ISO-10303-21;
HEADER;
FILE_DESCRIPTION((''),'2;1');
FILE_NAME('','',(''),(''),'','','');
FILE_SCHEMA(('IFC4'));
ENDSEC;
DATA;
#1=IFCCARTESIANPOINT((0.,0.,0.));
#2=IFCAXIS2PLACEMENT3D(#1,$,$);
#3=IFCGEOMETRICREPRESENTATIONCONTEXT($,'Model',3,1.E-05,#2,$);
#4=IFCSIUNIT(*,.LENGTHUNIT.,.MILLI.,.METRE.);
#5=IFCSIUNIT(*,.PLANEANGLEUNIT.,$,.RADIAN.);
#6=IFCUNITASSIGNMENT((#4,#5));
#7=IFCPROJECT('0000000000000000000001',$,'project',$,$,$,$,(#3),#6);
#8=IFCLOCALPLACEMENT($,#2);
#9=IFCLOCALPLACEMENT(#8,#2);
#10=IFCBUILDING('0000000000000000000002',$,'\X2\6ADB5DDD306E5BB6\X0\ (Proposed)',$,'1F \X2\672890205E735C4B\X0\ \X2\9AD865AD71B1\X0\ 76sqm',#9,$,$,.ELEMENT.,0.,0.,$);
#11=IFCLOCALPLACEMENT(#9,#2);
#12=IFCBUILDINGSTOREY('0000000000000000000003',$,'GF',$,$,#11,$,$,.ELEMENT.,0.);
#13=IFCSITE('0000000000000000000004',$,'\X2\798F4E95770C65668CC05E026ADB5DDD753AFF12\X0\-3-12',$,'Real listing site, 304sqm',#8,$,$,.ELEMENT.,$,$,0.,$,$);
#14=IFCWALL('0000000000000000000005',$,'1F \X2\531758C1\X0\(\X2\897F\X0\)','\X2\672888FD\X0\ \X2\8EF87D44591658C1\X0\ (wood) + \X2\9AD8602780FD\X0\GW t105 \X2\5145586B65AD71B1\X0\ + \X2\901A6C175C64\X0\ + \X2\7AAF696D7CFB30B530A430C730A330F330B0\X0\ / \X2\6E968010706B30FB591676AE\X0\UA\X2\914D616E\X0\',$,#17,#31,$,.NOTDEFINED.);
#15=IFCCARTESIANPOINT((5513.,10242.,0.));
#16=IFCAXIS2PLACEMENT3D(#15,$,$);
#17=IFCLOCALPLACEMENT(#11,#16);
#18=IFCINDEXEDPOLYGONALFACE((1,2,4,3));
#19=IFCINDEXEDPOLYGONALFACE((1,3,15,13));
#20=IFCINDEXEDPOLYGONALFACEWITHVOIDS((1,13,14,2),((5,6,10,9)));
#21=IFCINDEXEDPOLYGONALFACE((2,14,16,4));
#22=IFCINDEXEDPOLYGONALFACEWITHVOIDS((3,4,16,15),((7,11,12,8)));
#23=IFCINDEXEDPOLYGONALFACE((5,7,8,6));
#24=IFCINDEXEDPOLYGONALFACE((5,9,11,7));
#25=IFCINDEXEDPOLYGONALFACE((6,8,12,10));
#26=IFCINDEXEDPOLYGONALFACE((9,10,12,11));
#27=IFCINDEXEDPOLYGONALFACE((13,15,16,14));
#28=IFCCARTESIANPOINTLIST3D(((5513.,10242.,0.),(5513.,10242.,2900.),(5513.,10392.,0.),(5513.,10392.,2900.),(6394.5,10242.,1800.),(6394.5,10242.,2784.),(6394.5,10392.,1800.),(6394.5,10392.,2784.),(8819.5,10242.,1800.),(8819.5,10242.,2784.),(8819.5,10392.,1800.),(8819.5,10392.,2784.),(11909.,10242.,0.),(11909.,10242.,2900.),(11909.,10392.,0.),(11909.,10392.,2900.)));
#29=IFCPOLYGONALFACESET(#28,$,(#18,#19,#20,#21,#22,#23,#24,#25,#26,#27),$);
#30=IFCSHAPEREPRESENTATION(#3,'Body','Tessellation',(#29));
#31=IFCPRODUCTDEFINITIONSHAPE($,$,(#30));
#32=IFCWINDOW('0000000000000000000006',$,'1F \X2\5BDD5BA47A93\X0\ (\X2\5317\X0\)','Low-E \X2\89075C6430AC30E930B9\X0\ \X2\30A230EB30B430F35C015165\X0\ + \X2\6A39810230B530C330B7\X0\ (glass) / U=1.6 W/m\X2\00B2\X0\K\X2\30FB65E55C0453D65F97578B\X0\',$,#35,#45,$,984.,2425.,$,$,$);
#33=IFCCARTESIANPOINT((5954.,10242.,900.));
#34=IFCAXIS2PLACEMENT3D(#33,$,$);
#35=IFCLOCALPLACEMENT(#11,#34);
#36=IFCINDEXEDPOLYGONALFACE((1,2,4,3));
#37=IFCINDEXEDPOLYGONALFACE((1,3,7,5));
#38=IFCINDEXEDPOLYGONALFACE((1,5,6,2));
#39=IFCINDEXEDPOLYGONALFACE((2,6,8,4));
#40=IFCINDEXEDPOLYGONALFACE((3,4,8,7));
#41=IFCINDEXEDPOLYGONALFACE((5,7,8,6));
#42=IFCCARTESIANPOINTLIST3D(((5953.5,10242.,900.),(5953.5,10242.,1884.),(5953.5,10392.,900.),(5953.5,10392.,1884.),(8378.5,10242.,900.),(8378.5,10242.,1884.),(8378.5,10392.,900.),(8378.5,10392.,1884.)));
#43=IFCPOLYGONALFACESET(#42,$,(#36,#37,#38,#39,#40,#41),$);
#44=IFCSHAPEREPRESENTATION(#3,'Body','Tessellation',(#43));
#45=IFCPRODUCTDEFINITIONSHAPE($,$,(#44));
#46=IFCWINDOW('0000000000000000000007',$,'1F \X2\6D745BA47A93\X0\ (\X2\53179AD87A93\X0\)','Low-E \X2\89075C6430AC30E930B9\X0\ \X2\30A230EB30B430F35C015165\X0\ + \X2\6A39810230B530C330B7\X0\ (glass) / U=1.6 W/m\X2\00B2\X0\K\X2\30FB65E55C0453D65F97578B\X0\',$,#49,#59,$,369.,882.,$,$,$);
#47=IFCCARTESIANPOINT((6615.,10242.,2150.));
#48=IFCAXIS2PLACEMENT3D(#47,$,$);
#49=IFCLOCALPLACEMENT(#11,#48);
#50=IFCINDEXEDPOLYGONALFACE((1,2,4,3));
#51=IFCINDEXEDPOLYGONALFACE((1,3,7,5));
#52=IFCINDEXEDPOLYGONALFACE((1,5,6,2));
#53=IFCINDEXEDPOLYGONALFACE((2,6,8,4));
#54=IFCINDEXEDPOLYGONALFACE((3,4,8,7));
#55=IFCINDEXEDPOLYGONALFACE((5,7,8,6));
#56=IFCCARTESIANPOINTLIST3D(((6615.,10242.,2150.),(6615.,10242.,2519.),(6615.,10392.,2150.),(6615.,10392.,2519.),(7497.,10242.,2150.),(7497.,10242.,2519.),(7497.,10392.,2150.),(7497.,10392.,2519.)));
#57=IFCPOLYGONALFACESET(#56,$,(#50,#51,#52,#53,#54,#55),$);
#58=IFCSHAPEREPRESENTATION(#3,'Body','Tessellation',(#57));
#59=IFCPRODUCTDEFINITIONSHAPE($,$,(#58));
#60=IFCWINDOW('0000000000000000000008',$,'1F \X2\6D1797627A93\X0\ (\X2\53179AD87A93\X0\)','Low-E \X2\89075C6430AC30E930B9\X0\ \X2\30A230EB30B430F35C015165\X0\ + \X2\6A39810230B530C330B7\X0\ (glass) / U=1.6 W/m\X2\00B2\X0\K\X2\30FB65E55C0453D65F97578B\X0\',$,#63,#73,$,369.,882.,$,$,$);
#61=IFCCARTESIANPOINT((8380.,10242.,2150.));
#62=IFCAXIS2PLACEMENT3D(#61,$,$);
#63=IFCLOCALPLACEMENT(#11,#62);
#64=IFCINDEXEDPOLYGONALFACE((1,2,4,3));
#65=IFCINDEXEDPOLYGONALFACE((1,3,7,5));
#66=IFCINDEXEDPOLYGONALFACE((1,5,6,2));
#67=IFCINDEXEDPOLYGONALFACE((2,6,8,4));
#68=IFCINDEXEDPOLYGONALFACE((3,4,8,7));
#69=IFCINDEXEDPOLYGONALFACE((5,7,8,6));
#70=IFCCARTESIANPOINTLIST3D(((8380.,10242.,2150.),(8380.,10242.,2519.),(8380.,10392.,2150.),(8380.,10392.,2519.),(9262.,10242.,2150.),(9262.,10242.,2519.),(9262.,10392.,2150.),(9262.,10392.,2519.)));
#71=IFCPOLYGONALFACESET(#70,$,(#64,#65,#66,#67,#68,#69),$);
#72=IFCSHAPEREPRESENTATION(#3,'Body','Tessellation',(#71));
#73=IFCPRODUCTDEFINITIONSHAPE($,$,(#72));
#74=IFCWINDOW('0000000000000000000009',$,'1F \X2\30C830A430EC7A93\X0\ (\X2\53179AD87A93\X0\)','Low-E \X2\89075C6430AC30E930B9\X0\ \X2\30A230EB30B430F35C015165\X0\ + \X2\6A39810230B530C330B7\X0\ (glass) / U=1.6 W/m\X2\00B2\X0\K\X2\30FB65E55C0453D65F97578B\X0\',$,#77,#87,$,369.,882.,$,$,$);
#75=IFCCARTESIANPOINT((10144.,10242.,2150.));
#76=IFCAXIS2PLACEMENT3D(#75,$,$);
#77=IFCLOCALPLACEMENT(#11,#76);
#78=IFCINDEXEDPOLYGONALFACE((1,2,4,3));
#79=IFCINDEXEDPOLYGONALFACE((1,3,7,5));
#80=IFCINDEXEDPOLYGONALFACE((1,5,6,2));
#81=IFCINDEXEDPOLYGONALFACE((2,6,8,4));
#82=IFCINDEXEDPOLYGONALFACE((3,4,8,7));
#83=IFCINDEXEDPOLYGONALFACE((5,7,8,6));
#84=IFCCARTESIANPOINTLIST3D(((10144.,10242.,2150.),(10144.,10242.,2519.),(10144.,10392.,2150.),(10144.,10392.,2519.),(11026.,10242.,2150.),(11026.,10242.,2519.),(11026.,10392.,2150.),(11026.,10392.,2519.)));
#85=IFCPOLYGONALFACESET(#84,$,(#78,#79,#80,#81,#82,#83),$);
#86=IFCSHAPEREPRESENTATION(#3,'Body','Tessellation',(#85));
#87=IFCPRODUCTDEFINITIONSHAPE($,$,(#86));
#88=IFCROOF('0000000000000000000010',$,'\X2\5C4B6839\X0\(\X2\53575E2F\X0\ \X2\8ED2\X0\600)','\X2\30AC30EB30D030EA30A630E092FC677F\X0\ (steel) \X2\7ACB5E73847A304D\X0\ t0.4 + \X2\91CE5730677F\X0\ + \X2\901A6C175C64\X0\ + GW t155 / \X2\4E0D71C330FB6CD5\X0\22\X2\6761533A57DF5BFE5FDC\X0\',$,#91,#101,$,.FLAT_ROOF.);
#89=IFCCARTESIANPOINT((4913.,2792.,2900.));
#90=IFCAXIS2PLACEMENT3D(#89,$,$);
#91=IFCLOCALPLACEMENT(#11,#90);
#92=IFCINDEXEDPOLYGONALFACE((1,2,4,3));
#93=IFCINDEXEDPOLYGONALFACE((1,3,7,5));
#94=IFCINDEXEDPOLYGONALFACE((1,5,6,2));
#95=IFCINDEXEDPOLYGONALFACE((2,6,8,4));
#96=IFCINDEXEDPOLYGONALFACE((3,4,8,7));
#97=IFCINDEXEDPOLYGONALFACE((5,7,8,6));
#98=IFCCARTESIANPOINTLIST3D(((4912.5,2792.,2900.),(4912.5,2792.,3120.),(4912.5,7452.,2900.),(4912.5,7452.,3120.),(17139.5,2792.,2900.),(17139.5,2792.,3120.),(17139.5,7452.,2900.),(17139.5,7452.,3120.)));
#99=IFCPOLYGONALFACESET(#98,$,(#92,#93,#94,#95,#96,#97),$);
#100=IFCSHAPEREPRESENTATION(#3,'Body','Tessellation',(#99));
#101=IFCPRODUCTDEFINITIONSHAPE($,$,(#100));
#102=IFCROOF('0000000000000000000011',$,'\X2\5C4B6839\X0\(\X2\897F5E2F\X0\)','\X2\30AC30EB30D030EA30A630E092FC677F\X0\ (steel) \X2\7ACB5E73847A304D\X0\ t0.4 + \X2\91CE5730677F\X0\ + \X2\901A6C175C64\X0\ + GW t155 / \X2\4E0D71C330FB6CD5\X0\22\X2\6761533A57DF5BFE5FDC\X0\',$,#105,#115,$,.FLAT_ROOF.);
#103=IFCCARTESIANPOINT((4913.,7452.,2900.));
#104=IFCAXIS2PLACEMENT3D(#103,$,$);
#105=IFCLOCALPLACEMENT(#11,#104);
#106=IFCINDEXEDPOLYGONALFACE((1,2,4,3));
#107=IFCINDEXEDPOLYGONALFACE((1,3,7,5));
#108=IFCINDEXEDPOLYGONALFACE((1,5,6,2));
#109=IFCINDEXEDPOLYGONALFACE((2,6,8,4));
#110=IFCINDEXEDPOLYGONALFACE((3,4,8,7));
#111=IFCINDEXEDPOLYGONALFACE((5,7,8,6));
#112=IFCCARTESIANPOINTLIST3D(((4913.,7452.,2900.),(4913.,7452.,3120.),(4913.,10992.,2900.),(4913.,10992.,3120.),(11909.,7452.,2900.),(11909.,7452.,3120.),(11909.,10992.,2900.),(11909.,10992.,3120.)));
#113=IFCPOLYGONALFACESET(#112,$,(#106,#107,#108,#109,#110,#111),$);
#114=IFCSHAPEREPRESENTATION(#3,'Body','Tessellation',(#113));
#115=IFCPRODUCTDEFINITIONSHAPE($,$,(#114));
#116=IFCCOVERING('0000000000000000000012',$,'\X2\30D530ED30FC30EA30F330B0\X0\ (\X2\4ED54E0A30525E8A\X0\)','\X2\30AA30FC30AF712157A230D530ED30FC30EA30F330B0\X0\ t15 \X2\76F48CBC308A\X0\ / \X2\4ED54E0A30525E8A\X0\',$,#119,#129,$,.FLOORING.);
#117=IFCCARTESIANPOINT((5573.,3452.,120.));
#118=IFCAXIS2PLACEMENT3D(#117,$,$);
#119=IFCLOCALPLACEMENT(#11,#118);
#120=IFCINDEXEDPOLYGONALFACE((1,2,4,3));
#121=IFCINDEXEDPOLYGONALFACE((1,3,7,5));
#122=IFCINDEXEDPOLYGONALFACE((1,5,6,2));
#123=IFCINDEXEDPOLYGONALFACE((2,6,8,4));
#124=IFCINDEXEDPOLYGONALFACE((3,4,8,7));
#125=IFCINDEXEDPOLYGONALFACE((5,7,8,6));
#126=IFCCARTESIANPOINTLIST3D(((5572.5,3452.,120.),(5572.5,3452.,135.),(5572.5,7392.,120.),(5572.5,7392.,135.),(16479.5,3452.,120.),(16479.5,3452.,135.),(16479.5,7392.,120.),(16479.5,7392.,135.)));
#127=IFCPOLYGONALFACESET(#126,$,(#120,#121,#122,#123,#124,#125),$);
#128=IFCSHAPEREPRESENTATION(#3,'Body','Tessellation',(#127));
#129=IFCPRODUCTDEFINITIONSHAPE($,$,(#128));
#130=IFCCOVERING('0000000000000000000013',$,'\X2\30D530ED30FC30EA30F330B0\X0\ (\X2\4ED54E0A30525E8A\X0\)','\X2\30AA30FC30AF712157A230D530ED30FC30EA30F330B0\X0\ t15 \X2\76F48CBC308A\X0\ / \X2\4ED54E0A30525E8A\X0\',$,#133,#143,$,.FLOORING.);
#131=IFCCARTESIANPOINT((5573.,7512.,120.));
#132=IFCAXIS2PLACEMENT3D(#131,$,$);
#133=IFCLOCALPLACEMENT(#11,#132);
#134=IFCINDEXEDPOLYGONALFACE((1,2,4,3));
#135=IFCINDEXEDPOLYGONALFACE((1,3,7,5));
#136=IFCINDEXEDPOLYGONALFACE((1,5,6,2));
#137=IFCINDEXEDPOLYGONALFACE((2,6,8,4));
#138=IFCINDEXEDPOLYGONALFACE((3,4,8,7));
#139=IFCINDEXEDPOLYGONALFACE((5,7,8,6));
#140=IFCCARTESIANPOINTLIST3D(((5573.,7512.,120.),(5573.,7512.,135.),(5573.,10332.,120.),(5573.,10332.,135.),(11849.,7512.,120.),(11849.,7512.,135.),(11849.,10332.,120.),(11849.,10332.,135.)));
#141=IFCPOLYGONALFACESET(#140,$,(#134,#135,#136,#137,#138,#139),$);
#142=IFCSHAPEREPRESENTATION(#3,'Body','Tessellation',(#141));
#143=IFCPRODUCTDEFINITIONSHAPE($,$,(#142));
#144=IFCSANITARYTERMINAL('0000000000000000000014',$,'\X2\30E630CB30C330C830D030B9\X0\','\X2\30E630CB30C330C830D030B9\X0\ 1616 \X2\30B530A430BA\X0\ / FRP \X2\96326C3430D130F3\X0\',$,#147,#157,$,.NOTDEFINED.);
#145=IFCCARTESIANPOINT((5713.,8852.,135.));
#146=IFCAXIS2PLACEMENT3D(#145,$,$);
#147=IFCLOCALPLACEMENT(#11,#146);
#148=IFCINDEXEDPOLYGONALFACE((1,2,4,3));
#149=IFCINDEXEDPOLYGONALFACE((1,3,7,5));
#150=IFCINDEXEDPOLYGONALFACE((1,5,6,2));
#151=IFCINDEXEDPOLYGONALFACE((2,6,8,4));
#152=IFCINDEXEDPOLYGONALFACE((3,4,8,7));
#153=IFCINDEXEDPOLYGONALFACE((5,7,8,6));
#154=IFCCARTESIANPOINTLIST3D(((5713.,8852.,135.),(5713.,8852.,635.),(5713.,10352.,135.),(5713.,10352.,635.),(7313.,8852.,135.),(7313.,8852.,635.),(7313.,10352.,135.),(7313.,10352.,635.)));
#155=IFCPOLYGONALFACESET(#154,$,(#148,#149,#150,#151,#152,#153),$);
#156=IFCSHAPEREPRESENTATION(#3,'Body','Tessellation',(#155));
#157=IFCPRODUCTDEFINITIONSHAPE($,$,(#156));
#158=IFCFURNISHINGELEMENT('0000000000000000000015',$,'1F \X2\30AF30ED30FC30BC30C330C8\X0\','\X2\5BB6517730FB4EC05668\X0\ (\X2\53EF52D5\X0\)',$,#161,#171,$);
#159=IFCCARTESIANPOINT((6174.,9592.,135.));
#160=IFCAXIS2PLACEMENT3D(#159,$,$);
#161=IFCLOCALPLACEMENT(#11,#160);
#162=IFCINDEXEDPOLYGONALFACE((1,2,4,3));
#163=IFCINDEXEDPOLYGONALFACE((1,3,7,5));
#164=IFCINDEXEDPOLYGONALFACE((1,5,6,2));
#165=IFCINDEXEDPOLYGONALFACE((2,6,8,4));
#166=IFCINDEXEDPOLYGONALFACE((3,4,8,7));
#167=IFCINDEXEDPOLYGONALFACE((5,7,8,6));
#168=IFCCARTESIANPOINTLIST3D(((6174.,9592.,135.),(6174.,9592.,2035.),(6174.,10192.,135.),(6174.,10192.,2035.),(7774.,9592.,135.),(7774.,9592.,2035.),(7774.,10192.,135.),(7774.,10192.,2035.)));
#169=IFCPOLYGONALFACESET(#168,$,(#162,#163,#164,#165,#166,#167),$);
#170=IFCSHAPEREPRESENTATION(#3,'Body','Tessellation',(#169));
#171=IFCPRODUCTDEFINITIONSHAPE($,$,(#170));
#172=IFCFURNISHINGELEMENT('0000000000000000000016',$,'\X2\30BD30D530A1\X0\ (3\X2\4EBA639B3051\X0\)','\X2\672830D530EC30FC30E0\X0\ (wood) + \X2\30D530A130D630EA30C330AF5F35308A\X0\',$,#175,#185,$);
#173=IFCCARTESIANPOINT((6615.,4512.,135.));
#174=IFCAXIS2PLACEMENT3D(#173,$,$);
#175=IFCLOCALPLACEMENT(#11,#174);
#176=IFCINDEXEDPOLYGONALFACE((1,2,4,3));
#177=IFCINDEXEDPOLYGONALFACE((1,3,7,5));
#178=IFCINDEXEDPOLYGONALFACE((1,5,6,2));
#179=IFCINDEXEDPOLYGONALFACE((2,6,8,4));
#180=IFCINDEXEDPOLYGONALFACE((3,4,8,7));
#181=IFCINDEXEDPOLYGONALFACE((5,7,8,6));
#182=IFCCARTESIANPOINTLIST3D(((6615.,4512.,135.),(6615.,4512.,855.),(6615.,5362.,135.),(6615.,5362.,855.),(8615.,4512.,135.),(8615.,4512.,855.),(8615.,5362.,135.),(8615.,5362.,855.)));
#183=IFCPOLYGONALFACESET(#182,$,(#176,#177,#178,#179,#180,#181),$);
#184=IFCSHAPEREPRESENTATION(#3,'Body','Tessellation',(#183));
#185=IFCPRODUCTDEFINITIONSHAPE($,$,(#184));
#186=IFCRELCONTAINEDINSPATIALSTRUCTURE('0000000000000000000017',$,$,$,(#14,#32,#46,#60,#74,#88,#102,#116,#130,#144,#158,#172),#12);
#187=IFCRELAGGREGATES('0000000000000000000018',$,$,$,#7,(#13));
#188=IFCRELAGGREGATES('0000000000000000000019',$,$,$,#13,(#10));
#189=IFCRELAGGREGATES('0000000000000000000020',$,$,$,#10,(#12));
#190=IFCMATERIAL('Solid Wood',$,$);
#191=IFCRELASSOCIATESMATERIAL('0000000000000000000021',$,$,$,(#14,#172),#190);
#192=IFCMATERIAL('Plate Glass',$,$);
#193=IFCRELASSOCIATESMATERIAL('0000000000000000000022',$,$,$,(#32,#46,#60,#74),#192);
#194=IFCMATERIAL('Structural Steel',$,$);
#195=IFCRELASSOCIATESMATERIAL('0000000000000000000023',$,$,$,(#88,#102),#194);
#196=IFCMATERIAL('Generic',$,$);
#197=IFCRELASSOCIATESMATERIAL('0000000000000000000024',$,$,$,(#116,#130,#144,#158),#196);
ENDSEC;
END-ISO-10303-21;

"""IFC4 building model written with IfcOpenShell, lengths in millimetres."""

from ifc_helpers import new_model, si_unit, frame, frame_2d, origin, place, context, project, spatial, rectangle, extrude, material, element, fill, save


model = new_model("IFC4")

# Units and contexts
model_context = context("Model", 3, precision=1e-05, world=origin())
ifc_project = project(units=[si_unit("LENGTHUNIT", "METRE", prefix="MILLI"), si_unit("PLANEANGLEUNIT", "RADIAN")], contexts=[model_context])

# Site, building, storey
site_placement = place(None, origin())
site = spatial("IfcSite", under=ifc_project, at=site_placement, Name="福井県敦賀市櫛川町２-3-12", ObjectType="Real listing site, 304sqm", CompositionType="ELEMENT", RefElevation=0.0)
building_placement = place(site_placement, origin())
building = spatial("IfcBuilding", under=site, at=building_placement, Name="櫛川の家 (Proposed)", ObjectType="1F 木造平屋 高断熱 76sqm", CompositionType="ELEMENT", ElevationOfRefHeight=0.0, ElevationOfTerrain=0.0)
storey_placement = place(building_placement, origin())
storey = spatial("IfcBuildingStorey", under=building, at=storey_placement, Name="GF", CompositionType="ELEMENT", Elevation=0.0)

# Shared definitions
ifc_material_1 = material(Name="Solid Wood")

# Shared definitions
ifc_material_2 = material(Name="Plate Glass")

# Wall, openings, windows
wall_1_placement = place(storey_placement, frame((5513.0, 10242.0, 0.0)))
wall_1 = element("IfcWall", 1, at=wall_1_placement, inside=storey, material=ifc_material_1, Name="1F 北壁(西)", Description="木製 軸組外壁 (wood) + 高性能GW t105 充填断熱 + 通気層 + 窯業系サイディング / 準耐火・外皮UA配慮", PredefinedType="NOTDEFINED", context=model_context, shape_type="SweptSolid", body=[
    extrude(rectangle(XDim=6396.0, YDim=150.0, at=frame_2d((3198.0, 75.0))), frame((5513.0, 10242.0, 0.0)), (0.0, 0.0, 1.0), 2900.0),
])
opening_1_placement = place(storey_placement, frame((5954.0, 10242.0, 900.0)))
opening_1 = element("IfcOpeningElement", 2, at=opening_1_placement, cuts=wall_1, PredefinedType="NOTDEFINED", context=model_context, shape_type="SweptSolid", body=[
    extrude(rectangle(XDim=2425.0, YDim=150.0, at=frame_2d((1212.0, 75.0))), frame((5954.0, 10242.0, 900.0)), (0.0, 0.0, 1.0), 984.0),
])
opening_2_placement = place(storey_placement, frame((6615.0, 10242.0, 2150.0)))
opening_2 = element("IfcOpeningElement", 3, at=opening_2_placement, cuts=wall_1, PredefinedType="NOTDEFINED", context=model_context, shape_type="SweptSolid", body=[
    extrude(rectangle(XDim=882.0, YDim=150.0, at=frame_2d((441.0, 75.0))), frame((6615.0, 10242.0, 2150.0)), (0.0, 0.0, 1.0), 369.0),
])
opening_3_placement = place(storey_placement, frame((8380.0, 10242.0, 2150.0)))
opening_3 = element("IfcOpeningElement", 4, at=opening_3_placement, cuts=wall_1, PredefinedType="NOTDEFINED", context=model_context, shape_type="SweptSolid", body=[
    extrude(rectangle(XDim=882.0, YDim=150.0, at=frame_2d((441.0, 75.0))), frame((8380.0, 10242.0, 2150.0)), (0.0, 0.0, 1.0), 369.0),
])
opening_4_placement = place(storey_placement, frame((10144.0, 10242.0, 2150.0)))
opening_4 = element("IfcOpeningElement", 5, at=opening_4_placement, cuts=wall_1, PredefinedType="NOTDEFINED", context=model_context, shape_type="SweptSolid", body=[
    extrude(rectangle(XDim=882.0, YDim=150.0, at=frame_2d((441.0, 75.0))), frame((10144.0, 10242.0, 2150.0)), (0.0, 0.0, 1.0), 369.0),
])
window_1_placement = place(storey_placement, frame((5954.0, 10242.0, 900.0)))
window_1 = element("IfcWindow", 6, at=window_1_placement, inside=storey, material=ifc_material_2, Name="1F 寝室窓 (北)", Description="Low-E 複層ガラス アルゴン封入 + 樹脂サッシ (glass) / U=1.6 W/m²K・日射取得型", OverallHeight=984.0, OverallWidth=2425.0, context=model_context, shape_type="SweptSolid", body=[
    extrude(rectangle(XDim=2425.0, YDim=150.0, at=frame_2d((1212.0, 75.0))), frame((5954.0, 10242.0, 900.0)), (0.0, 0.0, 1.0), 984.0),
])
fill(opening_1, window_1)
window_2_placement = place(storey_placement, frame((6615.0, 10242.0, 2150.0)))
window_2 = element("IfcWindow", 7, at=window_2_placement, inside=storey, material=ifc_material_2, Name="1F 浴室窓 (北高窓)", Description="Low-E 複層ガラス アルゴン封入 + 樹脂サッシ (glass) / U=1.6 W/m²K・日射取得型", OverallHeight=369.0, OverallWidth=882.0, context=model_context, shape_type="SweptSolid", body=[
    extrude(rectangle(XDim=882.0, YDim=150.0, at=frame_2d((441.0, 75.0))), frame((6615.0, 10242.0, 2150.0)), (0.0, 0.0, 1.0), 369.0),
])
fill(opening_2, window_2)
window_3_placement = place(storey_placement, frame((8380.0, 10242.0, 2150.0)))
window_3 = element("IfcWindow", 8, at=window_3_placement, inside=storey, material=ifc_material_2, Name="1F 洗面窓 (北高窓)", Description="Low-E 複層ガラス アルゴン封入 + 樹脂サッシ (glass) / U=1.6 W/m²K・日射取得型", OverallHeight=369.0, OverallWidth=882.0, context=model_context, shape_type="SweptSolid", body=[
    extrude(rectangle(XDim=882.0, YDim=150.0, at=frame_2d((441.0, 75.0))), frame((8380.0, 10242.0, 2150.0)), (0.0, 0.0, 1.0), 369.0),
])
fill(opening_3, window_3)
window_4_placement = place(storey_placement, frame((10144.0, 10242.0, 2150.0)))
window_4 = element("IfcWindow", 9, at=window_4_placement, inside=storey, material=ifc_material_2, Name="1F トイレ窓 (北高窓)", Description="Low-E 複層ガラス アルゴン封入 + 樹脂サッシ (glass) / U=1.6 W/m²K・日射取得型", OverallHeight=369.0, OverallWidth=882.0, context=model_context, shape_type="SweptSolid", body=[
    extrude(rectangle(XDim=882.0, YDim=150.0, at=frame_2d((441.0, 75.0))), frame((10144.0, 10242.0, 2150.0)), (0.0, 0.0, 1.0), 369.0),
])
fill(opening_4, window_4)

# Roofs
ifc_material_3 = material(Name="Structural Steel")
roof_1_placement = place(storey_placement, frame((4913.0, 2792.0, 2900.0)))
element("IfcRoof", 10, at=roof_1_placement, inside=storey, material=ifc_material_3, Name="屋根(南帯 軒600)", Description="ガルバリウム鋼板 (steel) 立平葺き t0.4 + 野地板 + 通気層 + GW t155 / 不燃・法22条区域対応", PredefinedType="FLAT_ROOF", context=model_context, shape_type="SweptSolid", body=[
    extrude(rectangle(XDim=12227.0, YDim=4660.0, at=frame_2d((6113.0, 2330.0))), frame((4913.0, 2792.0, 2900.0)), (0.0, 0.0, 1.0), 220.0),
])
roof_2_placement = place(storey_placement, frame((4913.0, 7452.0, 2900.0)))
element("IfcRoof", 11, at=roof_2_placement, inside=storey, material=ifc_material_3, Name="屋根(西帯)", Description="ガルバリウム鋼板 (steel) 立平葺き t0.4 + 野地板 + 通気層 + GW t155 / 不燃・法22条区域対応", PredefinedType="FLAT_ROOF", context=model_context, shape_type="SweptSolid", body=[
    extrude(rectangle(XDim=6996.0, YDim=3540.0, at=frame_2d((3498.0, 1770.0))), frame((4913.0, 7452.0, 2900.0)), (0.0, 0.0, 1.0), 220.0),
])

# Coverings
ifc_material_4 = material(Name="Generic")
covering_1_placement = place(storey_placement, frame((5573.0, 3452.0, 120.0)))
element("IfcCovering", 12, at=covering_1_placement, inside=storey, material=ifc_material_4, Name="フローリング (仕上げ床)", Description="オーク無垢フローリング t15 直貼り / 仕上げ床", PredefinedType="FLOORING", context=model_context, shape_type="SweptSolid", body=[
    extrude(rectangle(XDim=10907.0, YDim=3940.0, at=frame_2d((5453.0, 1970.0))), frame((5573.0, 3452.0, 120.0)), (0.0, 0.0, 1.0), 15.0),
])
covering_2_placement = place(storey_placement, frame((5573.0, 7512.0, 120.0)))
element("IfcCovering", 13, at=covering_2_placement, inside=storey, material=ifc_material_4, Name="フローリング (仕上げ床)", Description="オーク無垢フローリング t15 直貼り / 仕上げ床", PredefinedType="FLOORING", context=model_context, shape_type="SweptSolid", body=[
    extrude(rectangle(XDim=6276.0, YDim=2820.0, at=frame_2d((3138.0, 1410.0))), frame((5573.0, 7512.0, 120.0)), (0.0, 0.0, 1.0), 15.0),
])

# Sanitary terminal
sanitary_terminal_placement = place(storey_placement, frame((5713.0, 8852.0, 135.0)))
element("IfcSanitaryTerminal", 14, at=sanitary_terminal_placement, inside=storey, material=ifc_material_4, Name="ユニットバス", Description="ユニットバス 1616 サイズ / FRP 防水パン", PredefinedType="NOTDEFINED", context=model_context, shape_type="SweptSolid", body=[
    extrude(rectangle(XDim=1600.0, YDim=1500.0, at=frame_2d((800.0, 750.0))), frame((5713.0, 8852.0, 135.0)), (0.0, 0.0, 1.0), 500.0),
])

# Furnishing elements
furnishing_1_placement = place(storey_placement, frame((6174.0, 9592.0, 135.0)))
element("IfcFurnishingElement", 15, at=furnishing_1_placement, inside=storey, material=ifc_material_4, Name="1F クローゼット", Description="家具・什器 (可動)", context=model_context, shape_type="SweptSolid", body=[
    extrude(rectangle(XDim=1600.0, YDim=600.0, at=frame_2d((800.0, 300.0))), frame((6174.0, 9592.0, 135.0)), (0.0, 0.0, 1.0), 1900.0),
])
furnishing_2_placement = place(storey_placement, frame((6615.0, 4512.0, 135.0)))
element("IfcFurnishingElement", 16, at=furnishing_2_placement, inside=storey, material=ifc_material_1, Name="ソファ (3人掛け)", Description="木フレーム (wood) + ファブリック張り", context=model_context, shape_type="SweptSolid", body=[
    extrude(rectangle(XDim=2000.0, YDim=850.0, at=frame_2d((1000.0, 425.0))), frame((6615.0, 4512.0, 135.0)), (0.0, 0.0, 1.0), 720.0),
])

save(model, "model.ifc")
